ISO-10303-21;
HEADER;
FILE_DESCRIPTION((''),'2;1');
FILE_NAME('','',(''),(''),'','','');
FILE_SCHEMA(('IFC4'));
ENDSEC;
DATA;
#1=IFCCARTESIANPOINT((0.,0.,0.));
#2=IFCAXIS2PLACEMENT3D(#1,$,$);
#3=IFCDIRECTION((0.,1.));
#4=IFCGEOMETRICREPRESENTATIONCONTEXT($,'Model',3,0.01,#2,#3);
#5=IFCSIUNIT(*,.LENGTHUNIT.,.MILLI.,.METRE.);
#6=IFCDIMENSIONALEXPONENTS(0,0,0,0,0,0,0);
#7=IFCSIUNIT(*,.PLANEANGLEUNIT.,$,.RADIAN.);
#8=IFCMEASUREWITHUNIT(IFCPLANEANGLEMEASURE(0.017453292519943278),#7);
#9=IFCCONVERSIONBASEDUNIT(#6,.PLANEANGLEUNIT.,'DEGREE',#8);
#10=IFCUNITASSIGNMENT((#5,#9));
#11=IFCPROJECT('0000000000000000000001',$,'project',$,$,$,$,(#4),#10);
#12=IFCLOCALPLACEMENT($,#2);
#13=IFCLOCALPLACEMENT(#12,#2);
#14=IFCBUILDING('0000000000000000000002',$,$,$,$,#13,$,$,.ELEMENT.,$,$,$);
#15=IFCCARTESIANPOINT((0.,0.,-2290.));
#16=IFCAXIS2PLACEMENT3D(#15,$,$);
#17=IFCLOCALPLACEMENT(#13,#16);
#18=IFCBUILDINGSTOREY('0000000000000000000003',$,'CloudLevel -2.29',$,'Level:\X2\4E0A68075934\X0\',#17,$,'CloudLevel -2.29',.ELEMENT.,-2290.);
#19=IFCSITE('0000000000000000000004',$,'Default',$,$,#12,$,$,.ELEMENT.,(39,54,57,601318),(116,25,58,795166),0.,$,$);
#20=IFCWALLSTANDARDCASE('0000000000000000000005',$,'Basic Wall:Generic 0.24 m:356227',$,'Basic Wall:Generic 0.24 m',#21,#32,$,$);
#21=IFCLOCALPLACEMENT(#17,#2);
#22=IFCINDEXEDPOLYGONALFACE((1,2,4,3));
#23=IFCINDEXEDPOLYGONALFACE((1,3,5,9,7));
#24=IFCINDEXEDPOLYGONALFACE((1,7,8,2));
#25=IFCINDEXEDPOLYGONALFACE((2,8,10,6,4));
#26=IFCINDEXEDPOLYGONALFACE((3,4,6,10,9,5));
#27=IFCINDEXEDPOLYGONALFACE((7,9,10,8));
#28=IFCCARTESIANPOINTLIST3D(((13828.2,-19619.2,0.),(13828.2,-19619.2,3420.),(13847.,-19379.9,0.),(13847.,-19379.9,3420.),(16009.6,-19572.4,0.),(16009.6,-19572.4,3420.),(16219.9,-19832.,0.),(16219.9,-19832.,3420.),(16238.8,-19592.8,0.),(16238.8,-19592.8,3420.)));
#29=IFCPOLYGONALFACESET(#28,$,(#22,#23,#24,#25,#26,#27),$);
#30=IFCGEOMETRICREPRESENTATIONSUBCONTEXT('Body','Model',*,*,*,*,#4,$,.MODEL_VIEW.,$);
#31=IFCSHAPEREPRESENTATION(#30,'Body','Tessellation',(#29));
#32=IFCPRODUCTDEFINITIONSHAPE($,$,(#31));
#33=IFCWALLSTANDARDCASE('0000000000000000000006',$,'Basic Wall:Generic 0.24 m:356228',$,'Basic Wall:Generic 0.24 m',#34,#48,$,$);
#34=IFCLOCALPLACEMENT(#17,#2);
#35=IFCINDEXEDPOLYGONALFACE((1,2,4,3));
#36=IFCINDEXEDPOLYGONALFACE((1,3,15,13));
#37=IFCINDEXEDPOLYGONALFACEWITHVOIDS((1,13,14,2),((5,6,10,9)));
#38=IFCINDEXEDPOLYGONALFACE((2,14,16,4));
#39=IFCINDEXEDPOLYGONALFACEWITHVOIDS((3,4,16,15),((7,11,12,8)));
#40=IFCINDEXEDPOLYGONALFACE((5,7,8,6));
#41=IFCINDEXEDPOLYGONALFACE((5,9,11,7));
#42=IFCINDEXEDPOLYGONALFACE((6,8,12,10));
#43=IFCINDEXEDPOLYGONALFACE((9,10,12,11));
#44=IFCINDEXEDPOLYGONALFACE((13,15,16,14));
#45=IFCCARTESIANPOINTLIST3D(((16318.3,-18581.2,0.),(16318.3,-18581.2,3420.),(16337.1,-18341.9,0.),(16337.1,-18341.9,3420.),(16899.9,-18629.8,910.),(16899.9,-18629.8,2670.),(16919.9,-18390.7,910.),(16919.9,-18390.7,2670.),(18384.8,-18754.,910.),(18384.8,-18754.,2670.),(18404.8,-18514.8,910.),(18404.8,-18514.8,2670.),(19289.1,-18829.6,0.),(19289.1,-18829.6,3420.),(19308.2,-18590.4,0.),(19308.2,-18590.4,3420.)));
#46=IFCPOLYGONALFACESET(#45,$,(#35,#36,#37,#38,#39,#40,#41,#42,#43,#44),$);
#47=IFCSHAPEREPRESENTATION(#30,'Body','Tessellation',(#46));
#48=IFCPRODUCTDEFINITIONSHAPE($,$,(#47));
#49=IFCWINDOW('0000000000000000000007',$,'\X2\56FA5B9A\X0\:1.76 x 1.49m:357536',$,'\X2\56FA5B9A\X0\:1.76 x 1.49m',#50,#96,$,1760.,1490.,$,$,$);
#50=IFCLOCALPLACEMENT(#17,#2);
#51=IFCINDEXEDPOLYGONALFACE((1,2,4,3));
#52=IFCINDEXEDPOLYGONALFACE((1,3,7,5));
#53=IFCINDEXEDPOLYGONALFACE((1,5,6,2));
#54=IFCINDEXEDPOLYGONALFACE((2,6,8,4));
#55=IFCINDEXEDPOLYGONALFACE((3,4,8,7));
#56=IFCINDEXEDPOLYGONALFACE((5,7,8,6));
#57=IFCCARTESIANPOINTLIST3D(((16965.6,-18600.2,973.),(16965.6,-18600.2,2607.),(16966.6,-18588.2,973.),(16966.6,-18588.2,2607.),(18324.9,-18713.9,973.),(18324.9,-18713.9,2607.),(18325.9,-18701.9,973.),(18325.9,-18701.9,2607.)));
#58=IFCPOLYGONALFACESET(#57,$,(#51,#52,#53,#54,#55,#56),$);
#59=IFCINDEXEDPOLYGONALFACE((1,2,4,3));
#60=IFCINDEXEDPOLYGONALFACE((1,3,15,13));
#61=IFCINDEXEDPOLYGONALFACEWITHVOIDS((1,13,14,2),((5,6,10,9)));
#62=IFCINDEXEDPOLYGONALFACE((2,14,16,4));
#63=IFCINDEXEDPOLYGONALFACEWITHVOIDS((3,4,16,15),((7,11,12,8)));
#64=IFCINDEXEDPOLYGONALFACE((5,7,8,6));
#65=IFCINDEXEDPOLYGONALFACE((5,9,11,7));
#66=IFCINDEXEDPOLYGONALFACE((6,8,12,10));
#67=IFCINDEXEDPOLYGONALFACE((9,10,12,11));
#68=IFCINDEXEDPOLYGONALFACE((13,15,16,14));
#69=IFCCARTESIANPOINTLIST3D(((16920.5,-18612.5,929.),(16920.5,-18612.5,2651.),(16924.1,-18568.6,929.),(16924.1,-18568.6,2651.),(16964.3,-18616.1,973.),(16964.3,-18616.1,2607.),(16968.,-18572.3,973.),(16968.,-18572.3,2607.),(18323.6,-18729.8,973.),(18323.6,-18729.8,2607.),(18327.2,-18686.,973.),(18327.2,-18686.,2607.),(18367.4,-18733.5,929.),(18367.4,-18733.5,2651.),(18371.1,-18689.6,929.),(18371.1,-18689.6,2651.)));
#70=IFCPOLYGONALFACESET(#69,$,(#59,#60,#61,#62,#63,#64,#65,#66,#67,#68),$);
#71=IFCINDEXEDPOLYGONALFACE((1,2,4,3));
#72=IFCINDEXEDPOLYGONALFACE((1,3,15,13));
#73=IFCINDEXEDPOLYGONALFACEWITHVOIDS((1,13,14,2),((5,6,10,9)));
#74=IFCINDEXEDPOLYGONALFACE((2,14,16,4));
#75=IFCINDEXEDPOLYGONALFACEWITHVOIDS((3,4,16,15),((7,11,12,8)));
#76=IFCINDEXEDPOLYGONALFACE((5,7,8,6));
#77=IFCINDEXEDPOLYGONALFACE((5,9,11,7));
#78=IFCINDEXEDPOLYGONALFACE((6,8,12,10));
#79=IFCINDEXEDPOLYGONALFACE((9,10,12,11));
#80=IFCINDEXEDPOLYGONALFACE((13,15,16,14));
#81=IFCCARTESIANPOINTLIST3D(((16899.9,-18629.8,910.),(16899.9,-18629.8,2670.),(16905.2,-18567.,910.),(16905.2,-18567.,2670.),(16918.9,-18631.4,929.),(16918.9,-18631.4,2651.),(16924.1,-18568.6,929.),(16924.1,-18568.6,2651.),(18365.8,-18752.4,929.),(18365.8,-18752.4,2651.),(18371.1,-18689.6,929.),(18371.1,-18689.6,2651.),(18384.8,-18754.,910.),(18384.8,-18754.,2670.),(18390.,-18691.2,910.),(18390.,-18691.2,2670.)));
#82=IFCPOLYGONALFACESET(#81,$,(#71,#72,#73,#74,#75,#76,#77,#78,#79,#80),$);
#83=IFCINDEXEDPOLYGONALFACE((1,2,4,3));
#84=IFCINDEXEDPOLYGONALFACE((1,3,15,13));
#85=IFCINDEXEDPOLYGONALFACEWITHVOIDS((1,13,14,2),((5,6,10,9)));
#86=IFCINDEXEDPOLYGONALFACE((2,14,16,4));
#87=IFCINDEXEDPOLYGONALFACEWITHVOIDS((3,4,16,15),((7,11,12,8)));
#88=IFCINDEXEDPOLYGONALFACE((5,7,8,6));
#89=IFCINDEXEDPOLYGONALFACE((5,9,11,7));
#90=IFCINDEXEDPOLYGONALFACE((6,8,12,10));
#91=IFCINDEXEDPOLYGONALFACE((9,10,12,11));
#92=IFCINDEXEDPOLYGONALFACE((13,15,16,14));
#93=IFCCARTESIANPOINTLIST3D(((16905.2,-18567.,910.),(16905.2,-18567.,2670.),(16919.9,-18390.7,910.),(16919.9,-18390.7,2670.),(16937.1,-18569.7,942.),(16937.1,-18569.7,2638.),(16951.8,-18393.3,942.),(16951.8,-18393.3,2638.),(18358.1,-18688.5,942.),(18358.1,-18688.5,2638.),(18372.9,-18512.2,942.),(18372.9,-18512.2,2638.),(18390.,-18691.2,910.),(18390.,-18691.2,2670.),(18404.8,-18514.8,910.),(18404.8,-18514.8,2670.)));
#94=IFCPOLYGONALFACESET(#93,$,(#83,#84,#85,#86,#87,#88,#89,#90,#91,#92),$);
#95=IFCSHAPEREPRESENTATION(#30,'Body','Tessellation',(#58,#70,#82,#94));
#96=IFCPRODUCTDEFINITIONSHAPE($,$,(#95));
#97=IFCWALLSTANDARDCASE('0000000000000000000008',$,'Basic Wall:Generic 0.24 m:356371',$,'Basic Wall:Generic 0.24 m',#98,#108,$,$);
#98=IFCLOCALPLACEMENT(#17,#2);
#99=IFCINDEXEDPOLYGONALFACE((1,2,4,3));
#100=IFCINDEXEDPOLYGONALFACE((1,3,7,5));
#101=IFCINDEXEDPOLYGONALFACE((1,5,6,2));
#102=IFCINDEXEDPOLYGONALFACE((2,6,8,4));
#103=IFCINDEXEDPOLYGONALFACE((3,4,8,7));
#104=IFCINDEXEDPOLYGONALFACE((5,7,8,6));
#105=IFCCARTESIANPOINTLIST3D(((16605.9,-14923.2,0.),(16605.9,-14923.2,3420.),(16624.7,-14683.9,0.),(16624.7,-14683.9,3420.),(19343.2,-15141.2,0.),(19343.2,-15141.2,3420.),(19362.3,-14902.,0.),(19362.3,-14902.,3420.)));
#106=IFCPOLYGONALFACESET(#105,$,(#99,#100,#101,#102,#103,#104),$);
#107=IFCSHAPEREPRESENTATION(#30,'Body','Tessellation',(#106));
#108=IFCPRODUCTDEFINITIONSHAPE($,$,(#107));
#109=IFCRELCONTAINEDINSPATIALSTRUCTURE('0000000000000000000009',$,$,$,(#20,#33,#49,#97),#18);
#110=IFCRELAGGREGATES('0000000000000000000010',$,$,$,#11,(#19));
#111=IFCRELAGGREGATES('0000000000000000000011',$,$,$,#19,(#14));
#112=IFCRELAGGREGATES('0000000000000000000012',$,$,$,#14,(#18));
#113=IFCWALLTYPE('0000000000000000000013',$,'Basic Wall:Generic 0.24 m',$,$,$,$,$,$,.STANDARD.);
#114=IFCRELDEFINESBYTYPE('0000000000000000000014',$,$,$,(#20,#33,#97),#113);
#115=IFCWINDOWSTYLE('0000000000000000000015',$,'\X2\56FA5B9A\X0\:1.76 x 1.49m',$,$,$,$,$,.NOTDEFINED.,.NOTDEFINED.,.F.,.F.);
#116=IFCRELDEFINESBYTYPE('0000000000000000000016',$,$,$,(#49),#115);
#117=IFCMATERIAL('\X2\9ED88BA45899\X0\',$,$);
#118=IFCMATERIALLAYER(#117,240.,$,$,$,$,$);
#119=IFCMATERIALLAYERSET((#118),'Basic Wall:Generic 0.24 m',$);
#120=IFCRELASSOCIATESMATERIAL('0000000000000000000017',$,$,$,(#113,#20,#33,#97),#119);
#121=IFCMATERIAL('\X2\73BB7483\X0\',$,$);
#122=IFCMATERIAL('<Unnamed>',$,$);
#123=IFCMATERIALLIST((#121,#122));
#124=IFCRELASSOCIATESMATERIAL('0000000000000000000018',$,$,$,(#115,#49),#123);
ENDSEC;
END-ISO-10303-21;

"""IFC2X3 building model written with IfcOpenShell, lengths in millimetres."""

from ifc_helpers import new_model, entity, si_unit, converted_unit, direction, frame, frame_2d, origin, place, context, subcontext, project, spatial, polyline, rectangle, outline, extrude, source, transform, mapped, material, material_list, layer, layer_set, layer_usage, type_object, type_shapes, element, fill, save


model = new_model("IFC2X3")

# Units and contexts
model_context = context("Model", 3, precision=0.01, world=origin(), true_north=direction((0.0, 1.0)))
body_context = subcontext(model_context, "Body", "Model", "MODEL_VIEW")
ifc_project = project(units=[si_unit("LENGTHUNIT", "METRE", prefix="MILLI"), converted_unit("PLANEANGLEUNIT", "DEGREE", entity("IfcPlaneAngleMeasure", 0.017453292519943278), si_unit("PLANEANGLEUNIT", "RADIAN"), dimensions=[0, 0, 0, 0, 0, 0, 0])], contexts=[model_context])

# Site, building, storey
site_placement = place(None, origin())
site = spatial("IfcSite", under=ifc_project, at=site_placement, Name="Default", CompositionType="ELEMENT", RefLatitude=(39, 54, 57, 601318), RefLongitude=(116, 25, 58, 795166), RefElevation=0.0)
building_placement = place(site_placement, origin())
building = spatial("IfcBuilding", under=site, at=building_placement, CompositionType="ELEMENT")
storey_placement = place(building_placement, frame((0.0, 0.0, -2290.0)))
storey = spatial("IfcBuildingStorey", under=building, at=storey_placement, Name="CloudLevel -2.29", ObjectType="Level:上标头", LongName="CloudLevel -2.29", CompositionType="ELEMENT", Elevation=-2290.0)

# Wall
ifc_material_1 = material(Name="默认墙")
ifc_layer_1 = layer(ifc_material_1, 240.0)
ifc_layer_set_1 = layer_set([ifc_layer_1], Name="Basic Wall:Generic 0.24 m")
ifc_layer_usage_1 = layer_usage(ifc_layer_set_1, "AXIS2", "NEGATIVE", 120.0)
wall_type_1 = type_object("IfcWallType", Name="Basic Wall:Generic 0.24 m", PredefinedType="STANDARD", material=ifc_layer_set_1)
wall_1_placement = place(storey_placement, frame((16230.6, -19712.5, 0.0), z_axis=(0.0, 0.0, 1.0), x_axis=(-0.996064, 0.088638, 0.0)))
element("IfcWallStandardCase", 1, at=wall_1_placement, inside=storey, type_object=wall_type_1, material=ifc_layer_usage_1, Name="Basic Wall:Generic 0.24 m:356227", ObjectType="Basic Wall:Generic 0.24 m", context=body_context, shape_type="SweptSolid", body=[
    extrude(outline(polyline([(2403.7, -120.0), (2401.2, 120.0), (0.0, 120.0), (2.5, -120.0), (232.5, -120.0), (2403.7, -120.0)])), origin(), (0.0, 0.0, 1.0), 3420.0),
])

# Wall, opening, window
wall_2_placement = place(storey_placement, frame((16327.1, -18461.5, 0.0), z_axis=(0.0, 0.0, 1.0), x_axis=(0.996521, -0.083339, 0.0)))
wall_2 = element("IfcWallStandardCase", 2, at=wall_2_placement, inside=storey, type_object=wall_type_1, material=ifc_layer_usage_1, Name="Basic Wall:Generic 0.24 m:356228", ObjectType="Basic Wall:Generic 0.24 m", context=body_context, shape_type="SweptSolid", body=[
    extrude(outline(polyline([(2982.4, -120.0), (2981.5, 120.0), (2741.5, 120.0), (0.0, 120.0), (1.2, -120.0), (2982.4, -120.0)])), origin(), (0.0, 0.0, 1.0), 3420.0),
])
opening_1_placement = place(wall_2_placement, frame((2074.9, 120.0, 910.0)))
opening_1 = element("IfcOpeningElement", 3, at=opening_1_placement, cuts=wall_2, ObjectType="Opening", context=body_context, shape_type="SweptSolid", body=[
    extrude(rectangle(XDim=1760.0, YDim=1490.0, at=frame_2d((880.0, 745.0), x_axis=(1.0, 0.0))), frame((0.0, 0.0, 0.0), z_axis=(0.0, -1.0, 0.0), x_axis=(0.0, 0.0, 1.0)), (0.0, 0.0, 1.0), 240.0),
])
ifc_material_2 = material(Name="玻璃")
ifc_material_3 = material(Name="<Unnamed>")
ifc_material_list_1 = material_list([ifc_material_2, ifc_material_3])
window_style_1 = type_object("IfcWindowStyle", Name="固定:1.76 x 1.49m", ConstructionType="NOTDEFINED", OperationType="NOTDEFINED", ParameterTakesPrecedence=False, Sizeable=False, material=ifc_material_list_1)
shared_shape_1 = source(origin(), body_context, "Body", "SweptSolid", [
    extrude(rectangle(XDim=1364.0, YDim=12.0, at=frame_2d((0.0, 0.0), x_axis=(1.0, 0.0))), frame((745.0, 225.0, 63.0), z_axis=(0.0, 0.0, 1.0), x_axis=(-1.0, 0.0, 0.0)), (0.0, 0.0, 1.0), 1634.0),
    extrude(outline(polyline([(-726.0, -861.0), (726.0, -861.0), (726.0, 861.0), (-726.0, 861.0), (-726.0, -861.0)]), holes=[polyline([(-682.0, -817.0), (-682.0, 817.0), (682.0, 817.0), (682.0, -817.0), (-682.0, -817.0)])]), frame((745.0, 247.0, 880.0), z_axis=(0.0, -1.0, 0.0), x_axis=(-1.0, 0.0, 0.0)), (0.0, 0.0, 1.0), 44.0),
    extrude(outline(polyline([(-745.0, -880.0), (745.0, -880.0), (745.0, 880.0), (-745.0, 880.0), (-745.0, -880.0)]), holes=[polyline([(-726.0, -861.0), (-726.0, 861.0), (726.0, 861.0), (726.0, -861.0), (-726.0, -861.0)])]), frame((745.0, 266.0, 880.0), z_axis=(0.0, -1.0, 0.0), x_axis=(-1.0, 0.0, 0.0)), (0.0, 0.0, 1.0), 63.0),
    extrude(outline(polyline([(-745.0, -880.0), (745.0, -880.0), (745.0, 880.0), (-745.0, 880.0), (-745.0, -880.0)]), holes=[polyline([(-713.0, -848.0), (-713.0, 848.0), (713.0, 848.0), (713.0, -848.0), (-713.0, -848.0)])]), frame((745.0, 203.0, 880.0), z_axis=(0.0, -1.0, 0.0), x_axis=(-1.0, 0.0, 0.0)), (0.0, 0.0, 1.0), 177.0),
])
type_shapes(window_style_1, [shared_shape_1])
window_1_placement = place(opening_1_placement, frame((0.0, 26.0, 0.0), z_axis=(0.0, 0.0, 1.0), x_axis=(-1.0, 0.0, 0.0)))
window_1 = element("IfcWindow", 4, at=window_1_placement, inside=storey, type_object=window_style_1, material=ifc_material_list_1, Name="固定:1.76 x 1.49m:357536", ObjectType="固定:1.76 x 1.49m", OverallHeight=1760.0, OverallWidth=1490.0, context=body_context, shape_type="MappedRepresentation", body=[
    mapped(shared_shape_1, transform((0.0, 0.0, 0.0), scale=1.0)),
])
fill(opening_1, window_1)

# Wall
wall_3_placement = place(storey_placement, frame((16615.2, -14803.5, 0.0), z_axis=(0.0, 0.0, 1.0), x_axis=(0.996843, -0.079393, 0.0)))
element("IfcWallStandardCase", 5, at=wall_3_placement, inside=storey, type_object=wall_type_1, material=ifc_layer_usage_1, Name="Basic Wall:Generic 0.24 m:356371", ObjectType="Basic Wall:Generic 0.24 m", context=body_context, shape_type="SweptSolid", body=[
    extrude(outline(polyline([(2746.2, -120.0), (2746.3, 120.0), (0.0, 120.0), (0.2, -120.0), (2746.2, -120.0)])), origin(), (0.0, 0.0, 1.0), 3420.0),
])

save(model, "model.ifc")
